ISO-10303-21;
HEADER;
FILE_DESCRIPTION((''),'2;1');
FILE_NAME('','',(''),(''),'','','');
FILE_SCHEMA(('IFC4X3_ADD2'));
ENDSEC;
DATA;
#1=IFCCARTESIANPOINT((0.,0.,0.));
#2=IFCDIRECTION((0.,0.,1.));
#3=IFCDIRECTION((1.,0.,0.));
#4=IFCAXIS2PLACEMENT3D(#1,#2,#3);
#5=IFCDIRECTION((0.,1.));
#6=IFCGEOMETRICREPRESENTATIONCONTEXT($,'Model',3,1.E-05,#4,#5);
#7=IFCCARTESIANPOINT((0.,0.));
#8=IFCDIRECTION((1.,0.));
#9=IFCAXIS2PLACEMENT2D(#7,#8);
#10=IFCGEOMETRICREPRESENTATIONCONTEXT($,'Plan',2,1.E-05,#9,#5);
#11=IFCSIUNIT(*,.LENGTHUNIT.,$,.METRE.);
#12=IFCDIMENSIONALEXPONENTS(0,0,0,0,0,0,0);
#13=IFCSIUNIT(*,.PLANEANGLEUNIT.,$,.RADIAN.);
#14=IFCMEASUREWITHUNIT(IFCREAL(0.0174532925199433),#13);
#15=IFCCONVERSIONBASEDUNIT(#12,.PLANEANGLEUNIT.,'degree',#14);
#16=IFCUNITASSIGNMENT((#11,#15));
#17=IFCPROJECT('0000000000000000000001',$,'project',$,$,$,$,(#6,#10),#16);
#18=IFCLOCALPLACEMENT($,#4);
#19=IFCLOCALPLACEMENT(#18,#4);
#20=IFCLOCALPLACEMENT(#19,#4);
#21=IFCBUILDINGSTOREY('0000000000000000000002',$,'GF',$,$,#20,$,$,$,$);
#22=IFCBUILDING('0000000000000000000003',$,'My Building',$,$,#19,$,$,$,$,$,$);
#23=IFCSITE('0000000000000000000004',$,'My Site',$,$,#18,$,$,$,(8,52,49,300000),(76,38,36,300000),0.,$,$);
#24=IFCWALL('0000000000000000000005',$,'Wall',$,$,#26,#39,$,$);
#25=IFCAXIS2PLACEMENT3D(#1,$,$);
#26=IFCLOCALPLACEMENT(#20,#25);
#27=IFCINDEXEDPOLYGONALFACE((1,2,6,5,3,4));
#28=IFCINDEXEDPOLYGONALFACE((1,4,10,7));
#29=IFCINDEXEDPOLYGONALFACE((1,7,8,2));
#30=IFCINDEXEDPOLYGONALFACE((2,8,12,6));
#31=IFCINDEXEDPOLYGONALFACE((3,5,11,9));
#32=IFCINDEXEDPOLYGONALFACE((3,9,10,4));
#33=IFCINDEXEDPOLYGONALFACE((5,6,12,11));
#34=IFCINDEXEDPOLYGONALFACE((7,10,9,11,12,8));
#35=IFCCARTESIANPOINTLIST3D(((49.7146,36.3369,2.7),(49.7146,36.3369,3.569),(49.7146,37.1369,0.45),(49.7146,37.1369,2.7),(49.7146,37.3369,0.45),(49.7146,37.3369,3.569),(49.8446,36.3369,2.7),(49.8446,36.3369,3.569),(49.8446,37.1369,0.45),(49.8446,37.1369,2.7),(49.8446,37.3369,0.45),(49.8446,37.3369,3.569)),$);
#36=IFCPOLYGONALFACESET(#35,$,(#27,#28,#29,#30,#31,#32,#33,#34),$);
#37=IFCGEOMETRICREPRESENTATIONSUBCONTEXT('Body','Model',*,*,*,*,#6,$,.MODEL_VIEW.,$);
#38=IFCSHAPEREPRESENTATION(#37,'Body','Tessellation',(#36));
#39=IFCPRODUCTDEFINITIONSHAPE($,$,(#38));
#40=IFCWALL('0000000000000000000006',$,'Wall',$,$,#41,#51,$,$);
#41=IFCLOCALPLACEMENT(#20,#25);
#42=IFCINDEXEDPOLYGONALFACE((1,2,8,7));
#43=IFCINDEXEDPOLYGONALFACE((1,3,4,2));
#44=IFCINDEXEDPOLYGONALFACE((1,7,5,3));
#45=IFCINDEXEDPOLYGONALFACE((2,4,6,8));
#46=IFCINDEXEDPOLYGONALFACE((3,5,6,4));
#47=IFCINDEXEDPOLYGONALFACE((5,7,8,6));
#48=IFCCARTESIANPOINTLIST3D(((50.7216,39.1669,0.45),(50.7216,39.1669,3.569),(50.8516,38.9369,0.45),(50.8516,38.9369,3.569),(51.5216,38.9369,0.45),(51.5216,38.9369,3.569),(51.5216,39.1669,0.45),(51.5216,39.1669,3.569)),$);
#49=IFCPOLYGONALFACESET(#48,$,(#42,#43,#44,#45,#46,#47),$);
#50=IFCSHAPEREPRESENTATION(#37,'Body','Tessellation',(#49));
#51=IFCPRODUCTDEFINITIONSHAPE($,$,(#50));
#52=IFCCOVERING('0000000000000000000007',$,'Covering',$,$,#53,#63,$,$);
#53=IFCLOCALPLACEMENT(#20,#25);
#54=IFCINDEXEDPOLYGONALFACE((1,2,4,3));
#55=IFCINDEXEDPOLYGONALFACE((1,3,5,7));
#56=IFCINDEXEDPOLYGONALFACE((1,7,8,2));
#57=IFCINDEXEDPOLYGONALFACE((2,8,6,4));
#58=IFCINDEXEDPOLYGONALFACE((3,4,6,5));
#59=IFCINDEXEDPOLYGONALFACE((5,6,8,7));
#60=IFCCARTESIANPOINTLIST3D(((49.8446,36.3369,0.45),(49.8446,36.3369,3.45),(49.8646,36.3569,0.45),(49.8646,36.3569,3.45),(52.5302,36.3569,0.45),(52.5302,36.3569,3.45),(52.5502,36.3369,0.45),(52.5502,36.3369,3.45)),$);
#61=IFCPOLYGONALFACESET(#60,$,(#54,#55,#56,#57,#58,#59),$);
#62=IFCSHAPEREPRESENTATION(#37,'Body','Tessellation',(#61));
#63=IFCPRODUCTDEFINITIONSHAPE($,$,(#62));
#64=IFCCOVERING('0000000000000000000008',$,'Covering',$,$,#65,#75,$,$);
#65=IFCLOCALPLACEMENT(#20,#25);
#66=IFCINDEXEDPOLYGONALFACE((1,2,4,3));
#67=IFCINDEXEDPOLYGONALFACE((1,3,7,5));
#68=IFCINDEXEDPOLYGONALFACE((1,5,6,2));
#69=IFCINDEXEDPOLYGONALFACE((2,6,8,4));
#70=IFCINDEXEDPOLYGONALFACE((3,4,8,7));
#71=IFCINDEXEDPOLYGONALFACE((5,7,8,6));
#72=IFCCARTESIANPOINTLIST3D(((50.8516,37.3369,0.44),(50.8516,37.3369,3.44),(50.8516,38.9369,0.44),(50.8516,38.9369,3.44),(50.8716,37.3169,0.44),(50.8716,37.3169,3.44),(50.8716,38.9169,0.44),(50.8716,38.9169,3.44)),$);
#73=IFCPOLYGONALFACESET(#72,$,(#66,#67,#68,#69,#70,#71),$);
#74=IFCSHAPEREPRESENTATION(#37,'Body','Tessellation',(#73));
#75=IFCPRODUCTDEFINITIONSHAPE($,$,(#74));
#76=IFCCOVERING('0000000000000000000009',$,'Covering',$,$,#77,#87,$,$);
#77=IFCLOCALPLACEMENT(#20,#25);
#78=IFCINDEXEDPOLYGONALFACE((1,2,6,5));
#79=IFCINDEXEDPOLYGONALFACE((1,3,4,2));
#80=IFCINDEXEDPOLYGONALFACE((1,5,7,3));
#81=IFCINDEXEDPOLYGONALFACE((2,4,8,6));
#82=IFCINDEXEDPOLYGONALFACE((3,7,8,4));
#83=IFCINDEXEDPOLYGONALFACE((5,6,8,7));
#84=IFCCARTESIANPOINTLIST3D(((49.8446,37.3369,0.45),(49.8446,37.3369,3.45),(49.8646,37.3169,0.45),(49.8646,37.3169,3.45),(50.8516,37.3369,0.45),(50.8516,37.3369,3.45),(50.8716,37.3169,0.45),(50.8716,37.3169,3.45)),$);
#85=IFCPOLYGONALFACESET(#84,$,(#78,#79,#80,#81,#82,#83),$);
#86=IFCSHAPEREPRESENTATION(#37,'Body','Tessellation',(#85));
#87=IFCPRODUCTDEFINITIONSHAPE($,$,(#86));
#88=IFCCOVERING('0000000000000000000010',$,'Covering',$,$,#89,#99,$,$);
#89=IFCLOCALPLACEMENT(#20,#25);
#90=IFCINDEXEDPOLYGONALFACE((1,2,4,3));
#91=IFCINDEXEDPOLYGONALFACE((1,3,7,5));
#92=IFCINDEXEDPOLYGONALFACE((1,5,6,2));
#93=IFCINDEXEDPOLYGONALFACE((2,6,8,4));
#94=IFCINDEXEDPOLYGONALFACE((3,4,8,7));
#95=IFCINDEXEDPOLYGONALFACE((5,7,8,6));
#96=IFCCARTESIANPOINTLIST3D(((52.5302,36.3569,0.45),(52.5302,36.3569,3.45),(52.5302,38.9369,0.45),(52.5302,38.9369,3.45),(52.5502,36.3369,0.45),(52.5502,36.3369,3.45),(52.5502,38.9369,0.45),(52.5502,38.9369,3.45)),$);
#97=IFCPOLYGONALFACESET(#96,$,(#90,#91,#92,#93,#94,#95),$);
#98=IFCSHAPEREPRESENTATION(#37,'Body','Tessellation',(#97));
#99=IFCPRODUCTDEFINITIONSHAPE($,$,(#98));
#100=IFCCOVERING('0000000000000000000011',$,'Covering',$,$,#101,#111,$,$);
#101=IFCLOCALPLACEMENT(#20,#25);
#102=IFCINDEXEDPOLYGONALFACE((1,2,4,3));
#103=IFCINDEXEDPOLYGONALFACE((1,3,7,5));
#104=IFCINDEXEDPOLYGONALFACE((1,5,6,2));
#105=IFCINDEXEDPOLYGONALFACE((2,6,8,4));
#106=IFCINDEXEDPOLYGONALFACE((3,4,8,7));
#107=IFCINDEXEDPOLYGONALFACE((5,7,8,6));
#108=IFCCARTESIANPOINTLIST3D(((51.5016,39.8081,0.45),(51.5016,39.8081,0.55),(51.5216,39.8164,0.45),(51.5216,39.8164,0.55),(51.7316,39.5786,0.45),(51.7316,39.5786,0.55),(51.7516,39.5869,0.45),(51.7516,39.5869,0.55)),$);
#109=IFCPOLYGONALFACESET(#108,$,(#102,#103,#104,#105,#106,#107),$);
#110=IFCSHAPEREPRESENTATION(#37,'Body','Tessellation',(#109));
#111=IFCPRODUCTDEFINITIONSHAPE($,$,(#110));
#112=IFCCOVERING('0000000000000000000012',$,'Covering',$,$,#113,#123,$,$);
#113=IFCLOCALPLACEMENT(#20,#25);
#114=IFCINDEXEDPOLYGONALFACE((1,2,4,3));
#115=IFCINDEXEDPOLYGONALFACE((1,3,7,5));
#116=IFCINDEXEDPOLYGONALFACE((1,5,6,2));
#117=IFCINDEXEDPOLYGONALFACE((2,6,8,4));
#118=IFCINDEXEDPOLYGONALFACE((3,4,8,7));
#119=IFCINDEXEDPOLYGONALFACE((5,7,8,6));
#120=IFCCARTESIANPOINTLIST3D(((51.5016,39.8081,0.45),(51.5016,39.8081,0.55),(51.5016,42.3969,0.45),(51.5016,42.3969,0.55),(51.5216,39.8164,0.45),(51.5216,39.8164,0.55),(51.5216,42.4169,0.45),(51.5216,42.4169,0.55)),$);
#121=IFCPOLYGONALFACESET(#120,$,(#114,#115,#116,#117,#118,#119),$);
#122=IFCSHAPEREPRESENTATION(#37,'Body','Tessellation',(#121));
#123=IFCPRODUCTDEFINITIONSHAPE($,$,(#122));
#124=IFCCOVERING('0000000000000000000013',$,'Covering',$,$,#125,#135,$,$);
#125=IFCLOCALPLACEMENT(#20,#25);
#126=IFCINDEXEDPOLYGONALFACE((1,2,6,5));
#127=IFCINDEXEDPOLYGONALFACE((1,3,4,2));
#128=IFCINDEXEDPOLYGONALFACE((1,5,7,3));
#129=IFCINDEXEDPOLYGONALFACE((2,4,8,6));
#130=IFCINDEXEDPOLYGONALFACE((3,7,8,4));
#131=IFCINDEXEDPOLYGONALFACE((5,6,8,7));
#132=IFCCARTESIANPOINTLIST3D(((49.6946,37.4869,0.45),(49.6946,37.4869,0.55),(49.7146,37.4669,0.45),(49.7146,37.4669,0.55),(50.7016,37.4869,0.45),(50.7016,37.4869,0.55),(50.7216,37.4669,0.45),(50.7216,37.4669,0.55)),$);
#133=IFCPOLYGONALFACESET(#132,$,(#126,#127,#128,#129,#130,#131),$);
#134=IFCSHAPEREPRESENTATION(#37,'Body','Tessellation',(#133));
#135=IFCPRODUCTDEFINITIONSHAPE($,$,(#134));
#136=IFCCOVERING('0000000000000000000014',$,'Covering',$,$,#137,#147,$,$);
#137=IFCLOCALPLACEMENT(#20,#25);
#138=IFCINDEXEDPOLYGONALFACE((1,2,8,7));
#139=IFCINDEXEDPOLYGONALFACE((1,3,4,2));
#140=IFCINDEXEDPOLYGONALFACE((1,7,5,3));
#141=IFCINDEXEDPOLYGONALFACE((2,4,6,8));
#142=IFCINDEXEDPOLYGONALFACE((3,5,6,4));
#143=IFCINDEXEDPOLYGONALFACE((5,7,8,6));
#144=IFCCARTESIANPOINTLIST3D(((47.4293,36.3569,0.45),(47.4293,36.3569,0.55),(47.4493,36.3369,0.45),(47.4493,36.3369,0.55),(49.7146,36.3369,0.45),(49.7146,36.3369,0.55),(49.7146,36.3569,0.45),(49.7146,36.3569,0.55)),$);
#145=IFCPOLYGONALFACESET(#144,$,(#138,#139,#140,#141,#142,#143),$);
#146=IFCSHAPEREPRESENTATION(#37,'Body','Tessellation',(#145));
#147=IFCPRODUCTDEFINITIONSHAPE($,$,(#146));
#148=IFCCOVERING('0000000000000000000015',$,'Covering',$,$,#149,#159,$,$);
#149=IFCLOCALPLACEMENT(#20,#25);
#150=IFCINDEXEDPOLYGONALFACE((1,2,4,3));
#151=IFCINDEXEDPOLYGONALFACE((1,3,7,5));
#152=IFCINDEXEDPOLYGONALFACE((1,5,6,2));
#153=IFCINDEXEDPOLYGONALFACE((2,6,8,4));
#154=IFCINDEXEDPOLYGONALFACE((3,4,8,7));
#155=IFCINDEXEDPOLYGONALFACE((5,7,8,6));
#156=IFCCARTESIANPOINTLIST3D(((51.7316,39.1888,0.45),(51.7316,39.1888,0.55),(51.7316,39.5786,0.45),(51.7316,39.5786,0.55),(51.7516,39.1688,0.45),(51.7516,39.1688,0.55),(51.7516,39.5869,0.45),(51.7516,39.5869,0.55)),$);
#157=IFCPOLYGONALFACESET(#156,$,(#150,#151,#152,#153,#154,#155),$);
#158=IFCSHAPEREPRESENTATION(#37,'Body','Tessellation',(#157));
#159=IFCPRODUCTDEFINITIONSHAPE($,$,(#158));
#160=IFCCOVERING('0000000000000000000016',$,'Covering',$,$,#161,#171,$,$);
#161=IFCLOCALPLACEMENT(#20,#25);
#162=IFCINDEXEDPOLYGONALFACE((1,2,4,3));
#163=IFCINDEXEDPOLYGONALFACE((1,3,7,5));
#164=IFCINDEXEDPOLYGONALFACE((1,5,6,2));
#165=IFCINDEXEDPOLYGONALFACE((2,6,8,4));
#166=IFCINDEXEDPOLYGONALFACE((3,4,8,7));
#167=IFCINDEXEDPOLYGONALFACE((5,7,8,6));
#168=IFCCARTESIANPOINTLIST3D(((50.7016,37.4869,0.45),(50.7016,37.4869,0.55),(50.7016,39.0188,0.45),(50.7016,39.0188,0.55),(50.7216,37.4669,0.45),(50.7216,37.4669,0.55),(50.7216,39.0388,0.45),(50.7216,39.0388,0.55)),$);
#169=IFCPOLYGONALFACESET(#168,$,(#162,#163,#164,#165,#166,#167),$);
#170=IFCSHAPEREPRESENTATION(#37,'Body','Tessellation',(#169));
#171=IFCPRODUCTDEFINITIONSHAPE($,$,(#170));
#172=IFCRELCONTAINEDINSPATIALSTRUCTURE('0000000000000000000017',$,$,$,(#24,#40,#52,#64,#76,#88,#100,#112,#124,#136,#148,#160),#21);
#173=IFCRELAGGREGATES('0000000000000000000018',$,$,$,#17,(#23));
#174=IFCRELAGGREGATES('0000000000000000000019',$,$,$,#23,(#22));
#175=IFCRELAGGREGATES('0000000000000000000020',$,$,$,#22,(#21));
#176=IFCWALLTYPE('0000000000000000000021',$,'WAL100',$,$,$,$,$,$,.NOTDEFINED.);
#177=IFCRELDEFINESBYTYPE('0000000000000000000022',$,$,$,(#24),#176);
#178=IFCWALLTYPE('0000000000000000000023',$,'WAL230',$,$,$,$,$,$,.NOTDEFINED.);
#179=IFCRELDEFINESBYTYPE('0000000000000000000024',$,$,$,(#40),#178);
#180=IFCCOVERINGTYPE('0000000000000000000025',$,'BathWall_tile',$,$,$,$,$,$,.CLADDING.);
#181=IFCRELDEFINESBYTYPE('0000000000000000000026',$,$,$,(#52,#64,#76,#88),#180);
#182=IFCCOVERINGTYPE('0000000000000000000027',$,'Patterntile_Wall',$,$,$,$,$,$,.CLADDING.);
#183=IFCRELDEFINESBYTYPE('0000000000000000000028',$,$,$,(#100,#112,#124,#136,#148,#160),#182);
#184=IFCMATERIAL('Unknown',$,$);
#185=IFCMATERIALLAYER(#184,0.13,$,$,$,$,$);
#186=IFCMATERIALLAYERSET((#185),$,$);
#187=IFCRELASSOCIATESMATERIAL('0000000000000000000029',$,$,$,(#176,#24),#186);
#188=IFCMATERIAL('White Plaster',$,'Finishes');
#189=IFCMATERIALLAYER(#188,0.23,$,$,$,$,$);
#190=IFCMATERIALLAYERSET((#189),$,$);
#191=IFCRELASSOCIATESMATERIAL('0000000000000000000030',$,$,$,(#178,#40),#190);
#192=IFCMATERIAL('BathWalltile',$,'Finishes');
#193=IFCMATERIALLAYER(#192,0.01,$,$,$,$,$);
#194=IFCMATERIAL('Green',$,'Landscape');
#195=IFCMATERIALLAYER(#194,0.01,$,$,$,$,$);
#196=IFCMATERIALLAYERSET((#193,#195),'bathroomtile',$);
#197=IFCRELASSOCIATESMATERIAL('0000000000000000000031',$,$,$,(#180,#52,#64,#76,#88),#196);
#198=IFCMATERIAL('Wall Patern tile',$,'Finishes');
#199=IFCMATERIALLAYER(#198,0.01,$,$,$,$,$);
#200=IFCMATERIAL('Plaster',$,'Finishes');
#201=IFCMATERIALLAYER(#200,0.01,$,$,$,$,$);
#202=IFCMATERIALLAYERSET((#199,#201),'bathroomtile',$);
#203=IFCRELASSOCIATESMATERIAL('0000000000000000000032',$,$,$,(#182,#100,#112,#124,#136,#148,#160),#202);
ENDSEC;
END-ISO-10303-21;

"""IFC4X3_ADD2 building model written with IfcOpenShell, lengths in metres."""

from ifc_helpers import new_model, entity, si_unit, converted_unit, direction, frame, origin_with_axes, origin_2d_with_axis, place, context, subcontext, project, spatial, line, indexed_curve, outline, extrude, source, transform, mapped, material, layer, layer_set, layer_usage, type_object, element, save


model = new_model("IFC4X3_ADD2")

# Units and contexts
model_context = context("Model", 3, precision=1e-05, world=origin_with_axes(), true_north=direction((0.0, 1.0)))
plan_context = context("Plan", 2, precision=1e-05, world=origin_2d_with_axis(), true_north=direction((0.0, 1.0)))
body_context_1 = subcontext(model_context, "Body", "Model", "MODEL_VIEW")
ifc_project = project(units=[si_unit("LENGTHUNIT", "METRE"), converted_unit("PLANEANGLEUNIT", "degree", entity("IfcReal", 0.0174532925199433), si_unit("PLANEANGLEUNIT", "RADIAN"), dimensions=[0, 0, 0, 0, 0, 0, 0])], contexts=[model_context, plan_context])

# Site, building, storey
site_placement = place(None, origin_with_axes())
site = spatial("IfcSite", under=ifc_project, at=site_placement, Name="My Site", RefLatitude=(8, 52, 49, 300000), RefLongitude=(76, 38, 36, 300000), RefElevation=0.0)
building_placement = place(site_placement, origin_with_axes())
building = spatial("IfcBuilding", under=site, at=building_placement, Name="My Building")
storey_placement = place(building_placement, origin_with_axes())
storey = spatial("IfcBuildingStorey", under=building, at=storey_placement, Name="GF")

# Shared definitions
ifc_material_1 = material(Name="Unknown")
ifc_layer_1 = layer(ifc_material_1, 0.13)
ifc_layer_set_1 = layer_set([ifc_layer_1])
wall_type_1 = type_object("IfcWallType", Name="WAL100", PredefinedType="NOTDEFINED", material=ifc_layer_set_1)

# Wall, opening
ifc_layer_usage_1 = layer_usage(ifc_layer_set_1, "AXIS2", "POSITIVE", 0.0)
wall_1_placement = place(storey_placement, frame((49.7146, 37.3369, 0.45), z_axis=(0.0, 0.0, 1.0), x_axis=(-0.000001, -1.0, 0.0)))
wall_1 = element("IfcWall", 1, at=wall_1_placement, inside=storey, type_object=wall_type_1, material=ifc_layer_usage_1, Name="Wall", context=body_context_1, shape_type="SweptSolid", body=[
    extrude(outline(indexed_curve([(0.0, 0.0), (0.0, 0.13), (1.0, 0.13), (1.0, 0.0)], segments=[line(1, 2, 3, 4, 1)])), origin_with_axes(), (0.0, 0.0, 1.0), 3.119),
])
shared_shape_1 = source(origin_with_axes(), body_context_1, "Body", "SweptSolid", [
    extrude(outline(indexed_curve([(0.0, 0.0), (0.8, 0.0), (0.8, 2.25), (0.0, 2.25)], segments=[line(1, 2, 3, 4, 1)])), frame((0.0, -0.6, 0.0), z_axis=(0.0, -1.0, 0.0), x_axis=(1.0, 0.0, 0.0)), (0.0, 0.0, -1.0), 1.2),
])
opening_1_placement = place(wall_1_placement, frame((0.2, 0.0, 0.0), z_axis=(0.0, 0.0, 1.0), x_axis=(1.0, 0.0, 0.0)))
element("IfcOpeningElement", 2, at=opening_1_placement, cuts=wall_1, PredefinedType="OPENING", context=body_context_1, shape_type="MappedRepresentation", body=[
    mapped(shared_shape_1, transform((0.0, 0.0, 0.0), x_axis=(1.0, 0.0, 0.0), y_axis=(0.0, 1.0, 0.0), z_axis=(0.0, 0.0, 1.0), scale=1.0)),
])

# Wall
ifc_material_2 = material(Name="White Plaster", Category="Finishes")
ifc_layer_2 = layer(ifc_material_2, 0.23)
ifc_layer_set_2 = layer_set([ifc_layer_2])
ifc_layer_usage_2 = layer_usage(ifc_layer_set_2, "AXIS2", "NEGATIVE", 0.0)
wall_type_2 = type_object("IfcWallType", Name="WAL230", PredefinedType="NOTDEFINED", material=ifc_layer_set_2)
wall_2_placement = place(storey_placement, frame((51.5216, 38.9369, 0.45), z_axis=(0.0, 0.0, 1.0), x_axis=(-1.0, 0.000001, 0.0)))
element("IfcWall", 3, at=wall_2_placement, inside=storey, type_object=wall_type_2, material=ifc_layer_usage_2, Name="Wall", context=body_context_1, shape_type="SweptSolid", body=[
    extrude(outline(indexed_curve([(0.0, -0.23), (0.0, 0.0), (0.67, 0.0), (0.8, -0.23)], segments=[line(1, 2, 3, 4, 1)])), origin_with_axes(), (0.0, 0.0, 1.0), 3.119),
])

# Coverings
ifc_material_3 = material(Name="BathWalltile", Category="Finishes")
ifc_layer_3 = layer(ifc_material_3, 0.01)
ifc_material_4 = material(Name="Green", Category="Landscape")
ifc_layer_4 = layer(ifc_material_4, 0.01)
ifc_layer_set_3 = layer_set([ifc_layer_3, ifc_layer_4], Name="bathroomtile")
ifc_layer_usage_3 = layer_usage(ifc_layer_set_3, "AXIS2", "POSITIVE", 0.0)
covering_type_1 = type_object("IfcCoveringType", Name="BathWall_tile", PredefinedType="CLADDING", material=ifc_layer_set_3)
covering_1_placement = place(storey_placement, frame((52.5302, 36.3569, 0.45), z_axis=(0.0, 0.0, 1.0), x_axis=(-1.0, 0.0, 0.0)))
element("IfcCovering", 4, at=covering_1_placement, inside=storey, type_object=covering_type_1, material=ifc_layer_usage_3, Name="Covering", context=body_context_1, shape_type="SweptSolid", body=[
    extrude(outline(indexed_curve([(0.0, 0.0), (-0.02, 0.02), (2.6856, 0.02), (2.6656, 0.0)], segments=[line(1, 2, 3, 4, 1)])), origin_with_axes(), (0.0, 0.0, 1.0), 3.0),
])
ifc_layer_usage_4 = layer_usage(ifc_layer_set_3, "AXIS2", "POSITIVE", 0.0)
covering_2_placement = place(storey_placement, frame((50.8716, 37.3169, 0.44), z_axis=(0.0, 0.0, 1.0), x_axis=(0.0, 1.0, 0.0)))
element("IfcCovering", 5, at=covering_2_placement, inside=storey, type_object=covering_type_1, material=ifc_layer_usage_4, Name="Covering", context=body_context_1, shape_type="SweptSolid", body=[
    extrude(outline(indexed_curve([(0.0, 0.0), (0.02, 0.02), (1.62, 0.02), (1.6, 0.0)], segments=[line(1, 2, 3, 4, 1)])), origin_with_axes(), (0.0, 0.0, 1.0), 3.0),
])
ifc_layer_usage_5 = layer_usage(ifc_layer_set_3, "AXIS2", "NEGATIVE", 0.0)
covering_3_placement = place(storey_placement, frame((50.8716, 37.3169, 0.45), z_axis=(0.0, 0.0, 1.0), x_axis=(-1.0, 0.0, 0.0)))
element("IfcCovering", 6, at=covering_3_placement, inside=storey, type_object=covering_type_1, material=ifc_layer_usage_5, Name="Covering", context=body_context_1, shape_type="SweptSolid", body=[
    extrude(outline(indexed_curve([(0.02, -0.02), (0.0, 0.0), (1.0071, 0.0), (1.0271, -0.02)], segments=[line(1, 2, 3, 4, 1)])), origin_with_axes(), (0.0, 0.0, 1.0), 3.0),
])
ifc_layer_usage_6 = layer_usage(ifc_layer_set_3, "AXIS2", "NEGATIVE", 0.0)
covering_4_placement = place(storey_placement, frame((52.5302, 36.3569, 0.45), z_axis=(0.0, 0.0, 1.0), x_axis=(0.0, 1.0, 0.0)))
element("IfcCovering", 7, at=covering_4_placement, inside=storey, type_object=covering_type_1, material=ifc_layer_usage_6, Name="Covering", context=body_context_1, shape_type="SweptSolid", body=[
    extrude(outline(indexed_curve([(-0.02, -0.02), (0.0, 0.0), (2.58, 0.0), (2.58, -0.02)], segments=[line(1, 2, 3, 4, 1)])), origin_with_axes(), (0.0, 0.0, 1.0), 3.0),
])
ifc_material_5 = material(Name="Wall Patern tile", Category="Finishes")
ifc_layer_5 = layer(ifc_material_5, 0.01)
ifc_material_6 = material(Name="Plaster", Category="Finishes")
ifc_layer_6 = layer(ifc_material_6, 0.01)
ifc_layer_set_4 = layer_set([ifc_layer_5, ifc_layer_6], Name="bathroomtile")
ifc_layer_usage_7 = layer_usage(ifc_layer_set_4, "AXIS2", "NEGATIVE", 0.0)
covering_type_2 = type_object("IfcCoveringType", Name="Patterntile_Wall", PredefinedType="CLADDING", material=ifc_layer_set_4)
covering_5_placement = place(storey_placement, frame((51.7316, 39.5786, 0.45), z_axis=(0.0, 0.0, 1.0), x_axis=(-0.70785, 0.706363, 0.0)))
element("IfcCovering", 8, at=covering_5_placement, inside=storey, type_object=covering_type_2, material=ifc_layer_usage_7, Name="Covering", context=body_context_1, shape_type="SweptSolid", body=[
    extrude(outline(indexed_curve([(-0.0083, -0.02), (0.0, 0.0), (0.3249, 0.0), (0.3166, -0.02)], segments=[line(1, 2, 3, 4, 1)])), origin_with_axes(), (0.0, 0.0, 1.0), 0.1),
])
ifc_layer_usage_8 = layer_usage(ifc_layer_set_4, "AXIS2", "NEGATIVE", 0.0)
covering_6_placement = place(storey_placement, frame((51.5016, 39.8081, 0.45), z_axis=(0.0, 0.0, 1.0), x_axis=(0.0, 1.0, 0.0)))
element("IfcCovering", 9, at=covering_6_placement, inside=storey, type_object=covering_type_2, material=ifc_layer_usage_8, Name="Covering", context=body_context_1, shape_type="SweptSolid", body=[
    extrude(outline(indexed_curve([(0.0083, -0.02), (0.0, 0.0), (2.5887, 0.0), (2.6087, -0.02)], segments=[line(1, 2, 3, 4, 1)])), origin_with_axes(), (0.0, 0.0, 1.0), 0.1),
])
ifc_layer_usage_9 = layer_usage(ifc_layer_set_4, "AXIS2", "POSITIVE", 0.0)
covering_7_placement = place(storey_placement, frame((50.7016, 37.4869, 0.45), z_axis=(0.0, 0.0, 1.0), x_axis=(-1.0, 0.0, 0.0)))
element("IfcCovering", 10, at=covering_7_placement, inside=storey, type_object=covering_type_2, material=ifc_layer_usage_9, Name="Covering", context=body_context_1, shape_type="SweptSolid", body=[
    extrude(outline(indexed_curve([(0.0, 0.0), (-0.02, 0.02), (0.9871, 0.02), (1.0071, 0.0)], segments=[line(1, 2, 3, 4, 1)])), origin_with_axes(), (0.0, 0.0, 1.0), 0.1),
])
ifc_layer_usage_10 = layer_usage(ifc_layer_set_4, "AXIS2", "POSITIVE", 0.0)
covering_8_placement = place(storey_placement, frame((49.7146, 36.3569, 0.45), z_axis=(0.0, 0.0, 1.0), x_axis=(-1.0, 0.000001, 0.0)))
element("IfcCovering", 11, at=covering_8_placement, inside=storey, type_object=covering_type_2, material=ifc_layer_usage_10, Name="Covering", context=body_context_1, shape_type="SweptSolid", body=[
    extrude(outline(indexed_curve([(0.0, 0.0), (0.0, 0.02), (2.2652, 0.02), (2.2852, 0.0)], segments=[line(1, 2, 3, 4, 1)])), origin_with_axes(), (0.0, 0.0, 1.0), 0.1),
])
ifc_layer_usage_11 = layer_usage(ifc_layer_set_4, "AXIS2", "NEGATIVE", 0.0)
covering_9_placement = place(storey_placement, frame((51.7316, 39.1888, 0.45), z_axis=(0.0, 0.0, 1.0), x_axis=(0.0, 1.0, 0.0)))
element("IfcCovering", 12, at=covering_9_placement, inside=storey, type_object=covering_type_2, material=ifc_layer_usage_11, Name="Covering", context=body_context_1, shape_type="SweptSolid", body=[
    extrude(outline(indexed_curve([(-0.02, -0.02), (0.0, 0.0), (0.3898, 0.0), (0.3981, -0.02)], segments=[line(1, 2, 3, 4, 1)])), origin_with_axes(), (0.0, 0.0, 1.0), 0.1),
])
ifc_layer_usage_12 = layer_usage(ifc_layer_set_4, "AXIS2", "NEGATIVE", 0.0)
covering_10_placement = place(storey_placement, frame((50.7016, 37.4869, 0.45), z_axis=(0.0, 0.0, 1.0), x_axis=(0.0, 1.0, 0.0)))
element("IfcCovering", 13, at=covering_10_placement, inside=storey, type_object=covering_type_2, material=ifc_layer_usage_12, Name="Covering", context=body_context_1, shape_type="SweptSolid", body=[
    extrude(outline(indexed_curve([(-0.02, -0.02), (0.0, 0.0), (1.5319, 0.0), (1.5519, -0.02)], segments=[line(1, 2, 3, 4, 1)])), origin_with_axes(), (0.0, 0.0, 1.0), 0.1),
])

save(model, "model.ifc")
